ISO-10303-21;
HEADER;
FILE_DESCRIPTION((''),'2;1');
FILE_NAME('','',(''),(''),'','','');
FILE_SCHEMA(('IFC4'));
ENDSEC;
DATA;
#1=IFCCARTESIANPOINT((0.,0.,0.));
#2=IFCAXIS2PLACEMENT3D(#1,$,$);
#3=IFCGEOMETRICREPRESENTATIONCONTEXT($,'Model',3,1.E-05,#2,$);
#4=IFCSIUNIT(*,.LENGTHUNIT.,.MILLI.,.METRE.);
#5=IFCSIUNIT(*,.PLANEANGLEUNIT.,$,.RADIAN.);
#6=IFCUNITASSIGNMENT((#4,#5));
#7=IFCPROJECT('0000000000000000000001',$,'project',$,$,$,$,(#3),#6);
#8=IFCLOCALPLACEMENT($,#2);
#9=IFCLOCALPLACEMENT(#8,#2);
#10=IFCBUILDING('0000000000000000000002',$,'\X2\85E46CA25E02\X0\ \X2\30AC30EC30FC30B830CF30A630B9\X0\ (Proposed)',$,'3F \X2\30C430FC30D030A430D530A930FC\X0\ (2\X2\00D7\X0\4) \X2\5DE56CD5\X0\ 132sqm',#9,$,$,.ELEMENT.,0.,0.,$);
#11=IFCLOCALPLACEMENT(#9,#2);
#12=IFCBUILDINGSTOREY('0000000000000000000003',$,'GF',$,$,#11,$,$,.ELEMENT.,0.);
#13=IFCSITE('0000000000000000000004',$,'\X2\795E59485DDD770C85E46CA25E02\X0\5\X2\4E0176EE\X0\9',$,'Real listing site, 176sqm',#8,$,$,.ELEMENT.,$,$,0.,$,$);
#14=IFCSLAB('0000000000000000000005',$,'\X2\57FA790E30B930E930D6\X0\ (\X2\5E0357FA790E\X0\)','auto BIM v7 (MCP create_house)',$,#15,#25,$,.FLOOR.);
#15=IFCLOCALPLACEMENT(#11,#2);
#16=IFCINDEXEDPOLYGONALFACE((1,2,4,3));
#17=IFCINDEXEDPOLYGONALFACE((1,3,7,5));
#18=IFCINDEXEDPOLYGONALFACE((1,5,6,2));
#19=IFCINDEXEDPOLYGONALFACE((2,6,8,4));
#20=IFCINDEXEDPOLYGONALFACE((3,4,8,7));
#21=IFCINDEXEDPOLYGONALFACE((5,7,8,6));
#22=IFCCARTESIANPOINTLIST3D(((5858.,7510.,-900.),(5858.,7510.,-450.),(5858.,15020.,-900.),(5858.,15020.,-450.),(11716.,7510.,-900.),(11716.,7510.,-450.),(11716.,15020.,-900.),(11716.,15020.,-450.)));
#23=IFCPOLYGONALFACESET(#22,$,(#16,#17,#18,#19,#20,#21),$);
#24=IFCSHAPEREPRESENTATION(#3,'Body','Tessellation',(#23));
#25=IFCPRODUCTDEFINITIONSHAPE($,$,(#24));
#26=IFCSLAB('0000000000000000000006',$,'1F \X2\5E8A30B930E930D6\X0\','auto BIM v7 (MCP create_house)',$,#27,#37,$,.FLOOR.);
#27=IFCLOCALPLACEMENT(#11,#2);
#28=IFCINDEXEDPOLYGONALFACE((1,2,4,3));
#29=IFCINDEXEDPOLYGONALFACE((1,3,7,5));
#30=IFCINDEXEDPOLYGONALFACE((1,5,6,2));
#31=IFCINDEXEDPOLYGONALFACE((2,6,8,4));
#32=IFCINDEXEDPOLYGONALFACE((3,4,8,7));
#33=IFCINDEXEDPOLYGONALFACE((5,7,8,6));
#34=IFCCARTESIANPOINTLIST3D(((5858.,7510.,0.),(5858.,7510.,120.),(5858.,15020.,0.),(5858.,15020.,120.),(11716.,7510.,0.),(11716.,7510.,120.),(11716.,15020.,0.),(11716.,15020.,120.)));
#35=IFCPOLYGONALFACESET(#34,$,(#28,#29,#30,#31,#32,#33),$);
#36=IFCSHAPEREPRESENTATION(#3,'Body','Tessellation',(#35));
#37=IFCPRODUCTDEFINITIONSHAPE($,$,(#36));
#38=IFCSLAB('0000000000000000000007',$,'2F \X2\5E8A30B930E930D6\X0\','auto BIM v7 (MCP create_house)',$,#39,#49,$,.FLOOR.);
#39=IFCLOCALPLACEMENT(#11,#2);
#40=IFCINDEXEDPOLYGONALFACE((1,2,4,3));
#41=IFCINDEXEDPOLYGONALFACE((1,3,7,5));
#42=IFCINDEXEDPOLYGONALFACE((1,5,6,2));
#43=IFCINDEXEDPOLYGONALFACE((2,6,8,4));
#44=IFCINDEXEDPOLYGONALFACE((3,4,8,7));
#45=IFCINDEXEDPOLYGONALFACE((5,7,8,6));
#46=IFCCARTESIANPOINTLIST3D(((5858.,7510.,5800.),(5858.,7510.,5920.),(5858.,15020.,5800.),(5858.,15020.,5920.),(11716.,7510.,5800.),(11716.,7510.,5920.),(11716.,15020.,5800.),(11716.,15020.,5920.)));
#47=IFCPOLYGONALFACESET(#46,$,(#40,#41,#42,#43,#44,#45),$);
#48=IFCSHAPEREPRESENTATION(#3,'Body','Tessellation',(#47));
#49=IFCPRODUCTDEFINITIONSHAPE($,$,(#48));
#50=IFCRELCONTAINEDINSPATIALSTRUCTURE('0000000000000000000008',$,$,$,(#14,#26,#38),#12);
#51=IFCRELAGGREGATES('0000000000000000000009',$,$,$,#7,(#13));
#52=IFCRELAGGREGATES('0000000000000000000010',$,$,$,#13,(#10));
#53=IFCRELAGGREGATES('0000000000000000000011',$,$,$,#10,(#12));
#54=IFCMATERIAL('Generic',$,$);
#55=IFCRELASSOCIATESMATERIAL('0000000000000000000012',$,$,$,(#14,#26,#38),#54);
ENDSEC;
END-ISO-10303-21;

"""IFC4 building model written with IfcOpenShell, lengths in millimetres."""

from ifc_helpers import new_model, si_unit, frame, frame_2d, origin, place, context, project, spatial, rectangle, extrude, material, element, save


model = new_model("IFC4")

# Units and contexts
model_context = context("Model", 3, precision=1e-05, world=origin())
ifc_project = project(units=[si_unit("LENGTHUNIT", "METRE", prefix="MILLI"), si_unit("PLANEANGLEUNIT", "RADIAN")], contexts=[model_context])

# Site, building, storey
site_placement = place(None, origin())
site = spatial("IfcSite", under=ifc_project, at=site_placement, Name="神奈川県藤沢市5丁目9", ObjectType="Real listing site, 176sqm", CompositionType="ELEMENT", RefElevation=0.0)
building_placement = place(site_placement, origin())
building = spatial("IfcBuilding", under=site, at=building_placement, Name="藤沢市 ガレージハウス (Proposed)", ObjectType="3F ツーバイフォー (2×4) 工法 132sqm", CompositionType="ELEMENT", ElevationOfRefHeight=0.0, ElevationOfTerrain=0.0)
storey_placement = place(building_placement, origin())
storey = spatial("IfcBuildingStorey", under=building, at=storey_placement, Name="GF", CompositionType="ELEMENT", Elevation=0.0)

# Slabs
ifc_material = material(Name="Generic")
slab_1_placement = place(storey_placement, frame((2929.0, 3755.0, -450.0)))
element("IfcSlab", 1, at=slab_1_placement, inside=storey, material=ifc_material, Name="基礎スラブ (布基礎)", Description="auto BIM v7 (MCP create_house)", PredefinedType="FLOOR", context=model_context, shape_type="SweptSolid", body=[
    extrude(rectangle(XDim=5858.0, YDim=7510.0, at=frame_2d((2929.0, 3755.0))), frame((2929.0, 3755.0, -450.0)), (0.0, 0.0, 1.0), 450.0),
])
slab_2_placement = place(storey_placement, frame((2929.0, 3755.0, 0.0)))
element("IfcSlab", 2, at=slab_2_placement, inside=storey, material=ifc_material, Name="1F 床スラブ", Description="auto BIM v7 (MCP create_house)", PredefinedType="FLOOR", context=model_context, shape_type="SweptSolid", body=[
    extrude(rectangle(XDim=5858.0, YDim=7510.0, at=frame_2d((2929.0, 3755.0))), frame((2929.0, 3755.0, 0.0)), (0.0, 0.0, 1.0), 120.0),
])
slab_3_placement = place(storey_placement, frame((2929.0, 3755.0, 2900.0)))
element("IfcSlab", 3, at=slab_3_placement, inside=storey, material=ifc_material, Name="2F 床スラブ", Description="auto BIM v7 (MCP create_house)", PredefinedType="FLOOR", context=model_context, shape_type="SweptSolid", body=[
    extrude(rectangle(XDim=5858.0, YDim=7510.0, at=frame_2d((2929.0, 3755.0))), frame((2929.0, 3755.0, 2900.0)), (0.0, 0.0, 1.0), 120.0),
])

save(model, "model.ifc")
